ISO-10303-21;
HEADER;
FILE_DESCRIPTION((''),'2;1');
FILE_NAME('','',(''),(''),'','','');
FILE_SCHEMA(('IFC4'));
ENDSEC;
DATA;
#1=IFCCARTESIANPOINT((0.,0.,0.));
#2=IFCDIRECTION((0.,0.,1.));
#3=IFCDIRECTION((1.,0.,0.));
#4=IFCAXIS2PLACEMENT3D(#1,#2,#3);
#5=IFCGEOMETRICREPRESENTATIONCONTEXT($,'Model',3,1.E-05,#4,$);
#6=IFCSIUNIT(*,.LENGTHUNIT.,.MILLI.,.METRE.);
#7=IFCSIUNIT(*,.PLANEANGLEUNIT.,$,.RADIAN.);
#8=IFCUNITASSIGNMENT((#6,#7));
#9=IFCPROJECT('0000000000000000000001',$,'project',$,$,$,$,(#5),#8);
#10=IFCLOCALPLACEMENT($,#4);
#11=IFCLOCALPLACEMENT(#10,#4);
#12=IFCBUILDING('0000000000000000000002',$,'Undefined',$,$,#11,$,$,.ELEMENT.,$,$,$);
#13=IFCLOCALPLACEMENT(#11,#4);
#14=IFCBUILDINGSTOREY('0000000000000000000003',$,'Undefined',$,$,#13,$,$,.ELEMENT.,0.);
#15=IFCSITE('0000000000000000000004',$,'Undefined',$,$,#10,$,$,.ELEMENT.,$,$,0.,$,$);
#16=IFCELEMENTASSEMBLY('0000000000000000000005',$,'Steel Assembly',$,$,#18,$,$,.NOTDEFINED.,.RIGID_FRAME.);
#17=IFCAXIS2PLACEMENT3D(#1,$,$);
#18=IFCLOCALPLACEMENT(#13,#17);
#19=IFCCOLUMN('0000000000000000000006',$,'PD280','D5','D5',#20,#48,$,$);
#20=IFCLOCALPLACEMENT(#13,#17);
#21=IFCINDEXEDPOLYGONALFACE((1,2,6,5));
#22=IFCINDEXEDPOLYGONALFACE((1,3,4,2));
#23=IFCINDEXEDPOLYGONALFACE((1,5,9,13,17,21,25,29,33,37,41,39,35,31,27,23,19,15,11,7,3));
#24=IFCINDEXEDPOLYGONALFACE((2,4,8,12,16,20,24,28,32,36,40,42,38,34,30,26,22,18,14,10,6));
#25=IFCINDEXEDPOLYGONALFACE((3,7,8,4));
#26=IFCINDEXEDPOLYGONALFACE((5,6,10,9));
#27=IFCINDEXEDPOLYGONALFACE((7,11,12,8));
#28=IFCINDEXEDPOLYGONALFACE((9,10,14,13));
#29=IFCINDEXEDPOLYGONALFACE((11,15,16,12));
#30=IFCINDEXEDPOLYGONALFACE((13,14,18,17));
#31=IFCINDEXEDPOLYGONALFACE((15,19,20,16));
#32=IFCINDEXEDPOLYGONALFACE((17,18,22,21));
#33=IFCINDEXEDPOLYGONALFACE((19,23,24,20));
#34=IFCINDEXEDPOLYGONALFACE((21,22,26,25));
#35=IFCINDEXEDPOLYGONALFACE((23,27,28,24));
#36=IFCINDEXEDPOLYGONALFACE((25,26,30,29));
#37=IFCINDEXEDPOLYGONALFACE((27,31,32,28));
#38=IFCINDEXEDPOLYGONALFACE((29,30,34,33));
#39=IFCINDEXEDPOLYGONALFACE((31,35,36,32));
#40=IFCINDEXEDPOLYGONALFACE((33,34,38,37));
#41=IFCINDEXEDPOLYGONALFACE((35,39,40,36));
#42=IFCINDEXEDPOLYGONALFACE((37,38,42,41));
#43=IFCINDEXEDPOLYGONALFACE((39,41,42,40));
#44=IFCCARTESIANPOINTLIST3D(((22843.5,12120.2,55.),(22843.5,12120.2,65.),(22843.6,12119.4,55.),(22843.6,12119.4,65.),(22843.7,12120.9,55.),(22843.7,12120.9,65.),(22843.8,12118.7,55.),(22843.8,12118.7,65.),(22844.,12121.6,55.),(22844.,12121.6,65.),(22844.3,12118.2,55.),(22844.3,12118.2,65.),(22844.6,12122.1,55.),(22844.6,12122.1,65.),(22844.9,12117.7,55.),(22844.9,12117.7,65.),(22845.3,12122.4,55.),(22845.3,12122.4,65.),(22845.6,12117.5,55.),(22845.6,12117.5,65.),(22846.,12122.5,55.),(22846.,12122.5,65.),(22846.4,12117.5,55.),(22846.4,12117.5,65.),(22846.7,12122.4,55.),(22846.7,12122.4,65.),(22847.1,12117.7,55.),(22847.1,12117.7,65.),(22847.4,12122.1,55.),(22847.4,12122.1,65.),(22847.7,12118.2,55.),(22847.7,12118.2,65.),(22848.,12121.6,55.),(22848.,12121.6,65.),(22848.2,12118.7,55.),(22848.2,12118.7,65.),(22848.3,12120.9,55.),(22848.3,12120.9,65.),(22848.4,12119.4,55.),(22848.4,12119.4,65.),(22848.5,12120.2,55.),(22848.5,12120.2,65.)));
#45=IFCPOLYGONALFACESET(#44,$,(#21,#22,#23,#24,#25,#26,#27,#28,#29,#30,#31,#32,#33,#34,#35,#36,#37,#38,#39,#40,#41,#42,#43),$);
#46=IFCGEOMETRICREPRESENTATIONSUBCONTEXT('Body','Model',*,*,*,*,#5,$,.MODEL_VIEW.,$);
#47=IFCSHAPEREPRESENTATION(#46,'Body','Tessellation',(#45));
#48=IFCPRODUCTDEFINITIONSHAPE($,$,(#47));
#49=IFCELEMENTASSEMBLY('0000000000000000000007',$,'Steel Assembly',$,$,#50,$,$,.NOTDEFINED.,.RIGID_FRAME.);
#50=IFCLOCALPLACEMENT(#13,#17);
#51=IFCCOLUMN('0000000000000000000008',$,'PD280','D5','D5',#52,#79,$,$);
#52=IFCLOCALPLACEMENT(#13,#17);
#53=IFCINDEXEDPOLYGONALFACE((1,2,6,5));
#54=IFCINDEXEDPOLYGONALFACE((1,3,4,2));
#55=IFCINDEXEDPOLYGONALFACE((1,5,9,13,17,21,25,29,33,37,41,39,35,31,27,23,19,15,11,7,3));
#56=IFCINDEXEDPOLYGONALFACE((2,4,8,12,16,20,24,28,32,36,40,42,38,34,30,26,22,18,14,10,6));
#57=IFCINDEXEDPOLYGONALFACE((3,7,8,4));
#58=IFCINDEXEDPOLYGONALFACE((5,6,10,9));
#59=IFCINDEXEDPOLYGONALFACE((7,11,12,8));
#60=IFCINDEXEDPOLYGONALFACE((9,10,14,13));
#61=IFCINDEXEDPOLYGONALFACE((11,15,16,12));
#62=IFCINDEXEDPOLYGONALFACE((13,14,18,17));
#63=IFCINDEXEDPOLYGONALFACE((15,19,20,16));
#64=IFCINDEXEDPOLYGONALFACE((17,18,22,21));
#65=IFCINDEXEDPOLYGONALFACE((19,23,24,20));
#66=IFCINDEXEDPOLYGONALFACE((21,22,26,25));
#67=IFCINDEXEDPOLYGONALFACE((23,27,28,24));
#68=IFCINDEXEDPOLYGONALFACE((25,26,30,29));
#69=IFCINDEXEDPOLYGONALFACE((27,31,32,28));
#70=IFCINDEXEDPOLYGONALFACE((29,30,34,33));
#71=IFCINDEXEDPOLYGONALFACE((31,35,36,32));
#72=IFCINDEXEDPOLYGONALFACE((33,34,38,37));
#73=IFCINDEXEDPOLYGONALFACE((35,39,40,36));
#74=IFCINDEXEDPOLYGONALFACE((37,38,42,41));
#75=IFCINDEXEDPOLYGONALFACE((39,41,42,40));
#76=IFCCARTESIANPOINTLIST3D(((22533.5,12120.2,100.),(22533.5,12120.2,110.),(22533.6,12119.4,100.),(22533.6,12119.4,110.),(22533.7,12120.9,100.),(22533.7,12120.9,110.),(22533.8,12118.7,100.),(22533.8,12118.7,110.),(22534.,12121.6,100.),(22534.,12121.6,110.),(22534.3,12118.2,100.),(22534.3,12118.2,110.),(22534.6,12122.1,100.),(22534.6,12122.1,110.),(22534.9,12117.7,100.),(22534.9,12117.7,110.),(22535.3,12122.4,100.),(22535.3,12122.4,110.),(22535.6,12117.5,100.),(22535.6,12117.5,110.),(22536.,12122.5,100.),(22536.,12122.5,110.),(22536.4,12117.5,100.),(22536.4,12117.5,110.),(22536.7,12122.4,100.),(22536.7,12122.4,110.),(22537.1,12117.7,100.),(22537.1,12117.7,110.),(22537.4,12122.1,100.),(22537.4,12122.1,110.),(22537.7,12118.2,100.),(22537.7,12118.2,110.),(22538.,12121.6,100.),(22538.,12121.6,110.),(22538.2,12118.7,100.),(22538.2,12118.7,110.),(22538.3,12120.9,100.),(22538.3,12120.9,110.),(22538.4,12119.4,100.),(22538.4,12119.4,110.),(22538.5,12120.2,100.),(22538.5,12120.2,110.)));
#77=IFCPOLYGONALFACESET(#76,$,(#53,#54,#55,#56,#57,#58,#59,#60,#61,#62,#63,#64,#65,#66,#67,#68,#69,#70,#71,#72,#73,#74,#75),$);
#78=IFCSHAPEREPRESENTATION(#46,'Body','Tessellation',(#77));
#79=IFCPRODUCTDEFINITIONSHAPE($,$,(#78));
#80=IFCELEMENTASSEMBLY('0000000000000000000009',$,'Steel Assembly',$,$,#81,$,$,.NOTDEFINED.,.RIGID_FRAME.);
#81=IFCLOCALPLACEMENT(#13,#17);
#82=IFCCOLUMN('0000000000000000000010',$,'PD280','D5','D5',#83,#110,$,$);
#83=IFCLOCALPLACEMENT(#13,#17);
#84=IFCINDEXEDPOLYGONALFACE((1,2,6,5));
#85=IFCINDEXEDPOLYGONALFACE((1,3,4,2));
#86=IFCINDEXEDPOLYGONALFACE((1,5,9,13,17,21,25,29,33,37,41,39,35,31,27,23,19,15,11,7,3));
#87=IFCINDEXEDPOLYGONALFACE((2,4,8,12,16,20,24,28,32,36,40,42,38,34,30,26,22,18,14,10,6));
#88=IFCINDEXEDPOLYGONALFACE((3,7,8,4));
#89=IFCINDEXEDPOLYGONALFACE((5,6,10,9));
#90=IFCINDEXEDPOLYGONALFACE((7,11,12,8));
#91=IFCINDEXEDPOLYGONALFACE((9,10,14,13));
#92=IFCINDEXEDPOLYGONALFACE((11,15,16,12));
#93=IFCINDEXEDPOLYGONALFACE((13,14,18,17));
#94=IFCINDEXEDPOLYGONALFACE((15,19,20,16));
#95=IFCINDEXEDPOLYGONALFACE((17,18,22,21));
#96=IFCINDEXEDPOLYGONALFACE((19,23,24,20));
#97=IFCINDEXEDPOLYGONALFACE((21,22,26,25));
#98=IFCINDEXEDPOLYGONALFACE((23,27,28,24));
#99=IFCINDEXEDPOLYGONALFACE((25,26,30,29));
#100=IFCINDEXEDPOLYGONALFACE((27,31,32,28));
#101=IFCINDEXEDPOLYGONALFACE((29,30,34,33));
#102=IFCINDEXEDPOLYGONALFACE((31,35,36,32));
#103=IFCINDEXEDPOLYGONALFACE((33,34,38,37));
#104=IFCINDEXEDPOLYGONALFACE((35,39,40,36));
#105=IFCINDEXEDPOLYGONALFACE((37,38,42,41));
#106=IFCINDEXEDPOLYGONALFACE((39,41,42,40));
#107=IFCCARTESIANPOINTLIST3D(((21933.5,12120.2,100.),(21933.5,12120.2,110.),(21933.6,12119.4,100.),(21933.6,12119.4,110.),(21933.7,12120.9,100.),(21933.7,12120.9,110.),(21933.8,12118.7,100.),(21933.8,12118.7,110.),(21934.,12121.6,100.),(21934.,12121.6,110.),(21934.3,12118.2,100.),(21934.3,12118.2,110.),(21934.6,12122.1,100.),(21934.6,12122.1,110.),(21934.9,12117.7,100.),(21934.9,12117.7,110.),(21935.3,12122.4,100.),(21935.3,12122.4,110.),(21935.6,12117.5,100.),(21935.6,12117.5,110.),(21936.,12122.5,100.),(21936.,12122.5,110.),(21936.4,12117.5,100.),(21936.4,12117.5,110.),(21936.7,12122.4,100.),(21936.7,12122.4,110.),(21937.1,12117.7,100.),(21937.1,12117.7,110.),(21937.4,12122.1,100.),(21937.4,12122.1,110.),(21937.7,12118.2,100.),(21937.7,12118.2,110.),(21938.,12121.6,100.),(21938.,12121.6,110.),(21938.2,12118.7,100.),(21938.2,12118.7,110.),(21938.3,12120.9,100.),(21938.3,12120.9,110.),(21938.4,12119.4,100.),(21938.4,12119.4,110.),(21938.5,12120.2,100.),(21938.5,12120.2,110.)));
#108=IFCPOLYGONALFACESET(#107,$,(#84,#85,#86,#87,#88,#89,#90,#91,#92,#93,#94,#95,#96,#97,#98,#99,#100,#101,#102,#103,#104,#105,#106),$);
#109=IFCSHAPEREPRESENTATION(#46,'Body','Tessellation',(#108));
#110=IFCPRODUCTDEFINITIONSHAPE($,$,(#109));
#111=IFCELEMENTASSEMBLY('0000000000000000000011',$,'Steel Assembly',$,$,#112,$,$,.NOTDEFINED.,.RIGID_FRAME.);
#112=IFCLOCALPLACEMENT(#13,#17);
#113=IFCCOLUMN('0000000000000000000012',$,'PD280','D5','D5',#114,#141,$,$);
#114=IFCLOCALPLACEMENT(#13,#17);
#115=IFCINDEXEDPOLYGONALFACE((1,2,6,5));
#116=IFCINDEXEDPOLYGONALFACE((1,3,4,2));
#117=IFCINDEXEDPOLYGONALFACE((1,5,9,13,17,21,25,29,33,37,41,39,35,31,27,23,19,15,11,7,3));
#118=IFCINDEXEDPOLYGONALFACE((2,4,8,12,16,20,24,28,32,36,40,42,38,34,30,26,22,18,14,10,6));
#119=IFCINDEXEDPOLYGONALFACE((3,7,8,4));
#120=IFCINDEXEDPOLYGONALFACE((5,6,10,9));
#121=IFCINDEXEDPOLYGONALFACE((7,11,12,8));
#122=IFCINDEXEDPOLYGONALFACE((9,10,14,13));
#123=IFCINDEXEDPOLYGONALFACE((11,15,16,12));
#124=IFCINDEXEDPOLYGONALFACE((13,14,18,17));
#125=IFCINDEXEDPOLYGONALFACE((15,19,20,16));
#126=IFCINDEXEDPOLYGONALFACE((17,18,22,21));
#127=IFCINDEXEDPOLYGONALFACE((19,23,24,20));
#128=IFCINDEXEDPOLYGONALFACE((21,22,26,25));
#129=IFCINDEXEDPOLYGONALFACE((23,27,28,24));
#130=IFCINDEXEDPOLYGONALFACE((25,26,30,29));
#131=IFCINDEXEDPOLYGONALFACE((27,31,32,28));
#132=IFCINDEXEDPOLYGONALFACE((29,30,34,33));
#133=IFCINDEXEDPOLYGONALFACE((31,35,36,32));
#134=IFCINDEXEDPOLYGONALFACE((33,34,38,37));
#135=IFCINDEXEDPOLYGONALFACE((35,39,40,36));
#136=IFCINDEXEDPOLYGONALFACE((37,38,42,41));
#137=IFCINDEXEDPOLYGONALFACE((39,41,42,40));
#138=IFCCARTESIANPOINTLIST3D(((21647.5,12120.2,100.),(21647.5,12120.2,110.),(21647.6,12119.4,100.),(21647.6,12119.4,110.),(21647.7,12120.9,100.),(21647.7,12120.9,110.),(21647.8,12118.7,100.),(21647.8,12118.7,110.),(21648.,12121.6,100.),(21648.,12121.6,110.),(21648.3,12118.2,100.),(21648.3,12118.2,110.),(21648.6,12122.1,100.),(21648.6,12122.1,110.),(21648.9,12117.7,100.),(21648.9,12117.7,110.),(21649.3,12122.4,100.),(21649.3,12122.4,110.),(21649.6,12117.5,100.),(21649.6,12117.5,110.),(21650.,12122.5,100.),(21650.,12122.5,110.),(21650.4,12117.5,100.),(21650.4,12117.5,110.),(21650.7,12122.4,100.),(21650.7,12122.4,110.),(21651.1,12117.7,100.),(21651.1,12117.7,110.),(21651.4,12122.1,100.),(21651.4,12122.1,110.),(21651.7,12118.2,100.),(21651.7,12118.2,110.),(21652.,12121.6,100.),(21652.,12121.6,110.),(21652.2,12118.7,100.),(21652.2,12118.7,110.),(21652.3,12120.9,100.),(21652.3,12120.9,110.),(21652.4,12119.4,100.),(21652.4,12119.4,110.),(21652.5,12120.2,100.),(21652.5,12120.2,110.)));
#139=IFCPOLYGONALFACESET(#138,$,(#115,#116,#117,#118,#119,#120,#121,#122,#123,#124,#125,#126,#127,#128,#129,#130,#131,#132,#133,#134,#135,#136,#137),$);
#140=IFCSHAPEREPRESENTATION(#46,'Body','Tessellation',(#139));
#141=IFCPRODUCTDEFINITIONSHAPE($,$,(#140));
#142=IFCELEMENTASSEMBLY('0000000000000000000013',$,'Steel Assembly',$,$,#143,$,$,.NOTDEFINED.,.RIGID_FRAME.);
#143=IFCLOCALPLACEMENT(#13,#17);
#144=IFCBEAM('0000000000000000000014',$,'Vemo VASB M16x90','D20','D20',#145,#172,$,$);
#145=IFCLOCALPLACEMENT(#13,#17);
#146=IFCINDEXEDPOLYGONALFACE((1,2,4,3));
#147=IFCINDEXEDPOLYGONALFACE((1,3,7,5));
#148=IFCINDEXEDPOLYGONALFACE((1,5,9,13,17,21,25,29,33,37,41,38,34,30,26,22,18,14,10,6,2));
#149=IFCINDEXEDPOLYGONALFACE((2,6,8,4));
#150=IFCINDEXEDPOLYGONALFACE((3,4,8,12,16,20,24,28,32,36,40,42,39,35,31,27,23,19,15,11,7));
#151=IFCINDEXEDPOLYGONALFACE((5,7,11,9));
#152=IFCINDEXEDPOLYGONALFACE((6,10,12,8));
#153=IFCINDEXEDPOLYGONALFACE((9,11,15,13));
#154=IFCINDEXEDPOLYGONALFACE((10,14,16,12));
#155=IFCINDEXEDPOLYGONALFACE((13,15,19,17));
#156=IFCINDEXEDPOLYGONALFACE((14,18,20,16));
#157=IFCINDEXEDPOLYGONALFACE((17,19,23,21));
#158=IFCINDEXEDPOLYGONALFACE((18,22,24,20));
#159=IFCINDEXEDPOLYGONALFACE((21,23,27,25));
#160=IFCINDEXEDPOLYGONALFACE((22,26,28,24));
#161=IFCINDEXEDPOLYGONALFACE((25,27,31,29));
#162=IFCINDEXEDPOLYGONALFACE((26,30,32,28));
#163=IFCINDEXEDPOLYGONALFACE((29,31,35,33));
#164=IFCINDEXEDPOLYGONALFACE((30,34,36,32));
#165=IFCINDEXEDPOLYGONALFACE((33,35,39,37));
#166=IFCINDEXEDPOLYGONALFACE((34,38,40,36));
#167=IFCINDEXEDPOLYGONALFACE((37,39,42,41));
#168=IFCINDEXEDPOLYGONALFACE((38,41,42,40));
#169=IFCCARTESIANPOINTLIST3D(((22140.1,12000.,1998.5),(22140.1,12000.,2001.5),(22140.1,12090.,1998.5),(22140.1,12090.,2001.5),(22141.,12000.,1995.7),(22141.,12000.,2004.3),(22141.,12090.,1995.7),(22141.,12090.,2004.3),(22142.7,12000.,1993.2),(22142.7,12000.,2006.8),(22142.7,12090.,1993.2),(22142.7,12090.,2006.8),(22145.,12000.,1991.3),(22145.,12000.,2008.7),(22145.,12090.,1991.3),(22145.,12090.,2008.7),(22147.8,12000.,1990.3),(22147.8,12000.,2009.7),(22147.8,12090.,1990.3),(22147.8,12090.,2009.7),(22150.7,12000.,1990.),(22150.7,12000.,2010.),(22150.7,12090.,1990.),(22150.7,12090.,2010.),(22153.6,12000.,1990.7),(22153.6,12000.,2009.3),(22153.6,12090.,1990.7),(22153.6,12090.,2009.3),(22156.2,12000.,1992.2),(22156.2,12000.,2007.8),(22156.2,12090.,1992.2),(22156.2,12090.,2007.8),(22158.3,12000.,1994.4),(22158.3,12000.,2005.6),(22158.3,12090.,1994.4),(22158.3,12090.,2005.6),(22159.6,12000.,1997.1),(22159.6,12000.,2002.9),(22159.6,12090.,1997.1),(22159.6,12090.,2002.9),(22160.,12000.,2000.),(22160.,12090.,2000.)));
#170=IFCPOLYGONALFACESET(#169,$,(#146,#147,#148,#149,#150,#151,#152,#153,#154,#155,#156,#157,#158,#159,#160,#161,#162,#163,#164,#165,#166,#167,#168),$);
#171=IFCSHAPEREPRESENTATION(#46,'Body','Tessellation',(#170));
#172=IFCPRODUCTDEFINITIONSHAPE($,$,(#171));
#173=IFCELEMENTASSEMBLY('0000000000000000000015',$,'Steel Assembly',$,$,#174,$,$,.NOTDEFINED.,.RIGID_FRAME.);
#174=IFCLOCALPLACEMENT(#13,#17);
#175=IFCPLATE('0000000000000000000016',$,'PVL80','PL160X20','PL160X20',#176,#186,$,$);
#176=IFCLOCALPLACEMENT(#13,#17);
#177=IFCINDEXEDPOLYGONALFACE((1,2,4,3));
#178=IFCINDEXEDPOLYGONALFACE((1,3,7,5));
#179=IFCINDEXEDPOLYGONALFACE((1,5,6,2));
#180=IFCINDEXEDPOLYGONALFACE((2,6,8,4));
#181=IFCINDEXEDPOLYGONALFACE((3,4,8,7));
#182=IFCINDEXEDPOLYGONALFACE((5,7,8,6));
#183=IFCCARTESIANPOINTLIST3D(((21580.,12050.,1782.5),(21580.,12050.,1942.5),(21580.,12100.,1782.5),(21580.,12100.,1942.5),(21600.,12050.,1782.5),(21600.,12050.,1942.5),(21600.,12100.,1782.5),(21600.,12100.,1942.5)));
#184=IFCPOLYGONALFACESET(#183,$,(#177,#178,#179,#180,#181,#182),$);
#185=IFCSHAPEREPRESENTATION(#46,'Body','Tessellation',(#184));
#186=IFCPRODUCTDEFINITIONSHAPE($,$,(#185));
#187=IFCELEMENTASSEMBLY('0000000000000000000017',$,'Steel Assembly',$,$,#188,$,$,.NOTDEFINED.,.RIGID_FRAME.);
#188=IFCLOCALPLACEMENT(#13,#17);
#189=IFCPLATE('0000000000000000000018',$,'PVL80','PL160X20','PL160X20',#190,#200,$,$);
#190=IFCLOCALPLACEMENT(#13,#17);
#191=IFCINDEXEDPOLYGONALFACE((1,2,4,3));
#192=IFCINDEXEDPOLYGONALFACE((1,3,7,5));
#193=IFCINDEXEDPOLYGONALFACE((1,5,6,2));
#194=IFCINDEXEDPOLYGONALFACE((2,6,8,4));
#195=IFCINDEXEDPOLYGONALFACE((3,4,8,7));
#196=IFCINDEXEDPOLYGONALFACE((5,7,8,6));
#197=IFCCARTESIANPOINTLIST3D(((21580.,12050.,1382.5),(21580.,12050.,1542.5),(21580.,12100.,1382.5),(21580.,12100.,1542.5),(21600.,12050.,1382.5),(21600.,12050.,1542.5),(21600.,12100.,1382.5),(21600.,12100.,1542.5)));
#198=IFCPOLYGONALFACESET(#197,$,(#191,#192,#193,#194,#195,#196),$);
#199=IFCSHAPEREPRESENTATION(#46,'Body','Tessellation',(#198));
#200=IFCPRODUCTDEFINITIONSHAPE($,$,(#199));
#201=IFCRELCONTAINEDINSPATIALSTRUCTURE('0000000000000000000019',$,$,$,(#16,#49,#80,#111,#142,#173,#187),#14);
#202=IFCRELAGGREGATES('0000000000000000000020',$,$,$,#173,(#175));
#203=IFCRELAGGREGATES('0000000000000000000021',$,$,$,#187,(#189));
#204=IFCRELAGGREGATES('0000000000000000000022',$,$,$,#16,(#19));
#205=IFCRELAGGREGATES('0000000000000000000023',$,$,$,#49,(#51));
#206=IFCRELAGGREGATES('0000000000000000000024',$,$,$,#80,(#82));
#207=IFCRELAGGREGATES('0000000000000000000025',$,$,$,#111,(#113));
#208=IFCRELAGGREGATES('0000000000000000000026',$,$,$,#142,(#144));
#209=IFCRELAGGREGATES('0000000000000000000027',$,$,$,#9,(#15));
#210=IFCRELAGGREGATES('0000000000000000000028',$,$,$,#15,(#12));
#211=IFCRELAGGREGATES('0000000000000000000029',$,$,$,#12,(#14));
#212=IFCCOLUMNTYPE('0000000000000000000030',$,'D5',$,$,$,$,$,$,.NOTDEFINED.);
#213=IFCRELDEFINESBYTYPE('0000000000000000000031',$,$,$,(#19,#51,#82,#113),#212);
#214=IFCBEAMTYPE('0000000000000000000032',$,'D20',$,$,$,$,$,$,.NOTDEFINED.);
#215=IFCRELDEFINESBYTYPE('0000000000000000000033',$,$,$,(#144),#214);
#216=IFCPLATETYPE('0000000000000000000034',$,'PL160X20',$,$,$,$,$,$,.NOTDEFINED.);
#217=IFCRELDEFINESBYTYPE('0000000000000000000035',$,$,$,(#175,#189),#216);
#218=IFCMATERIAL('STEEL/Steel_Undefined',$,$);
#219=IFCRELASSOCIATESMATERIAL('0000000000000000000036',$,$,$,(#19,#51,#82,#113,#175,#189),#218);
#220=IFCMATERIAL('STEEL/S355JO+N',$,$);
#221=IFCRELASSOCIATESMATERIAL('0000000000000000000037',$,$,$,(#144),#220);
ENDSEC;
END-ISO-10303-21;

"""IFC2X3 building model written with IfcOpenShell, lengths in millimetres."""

from ifc_helpers import new_model, si_unit, frame, origin_with_axes, origin_2d_with_axis, place, context, subcontext, project, spatial, polyline, circle, outline, extrude, material, type_object, element, aggregate, save


model = new_model("IFC2X3")

# Units and contexts
model_context = context("Model", 3, precision=1e-05, world=origin_with_axes())
body_context = subcontext(model_context, "Body", "Model", "MODEL_VIEW")
ifc_project = project(units=[si_unit("LENGTHUNIT", "METRE", prefix="MILLI"), si_unit("PLANEANGLEUNIT", "RADIAN")], contexts=[model_context])

# Site, building, storey
site_placement = place(None, origin_with_axes())
site = spatial("IfcSite", under=ifc_project, at=site_placement, Name="Undefined", CompositionType="ELEMENT", RefElevation=0.0)
building_placement = place(site_placement, origin_with_axes())
building = spatial("IfcBuilding", under=site, at=building_placement, Name="Undefined", CompositionType="ELEMENT")
storey_placement = place(building_placement, origin_with_axes())
storey = spatial("IfcBuildingStorey", under=building, at=storey_placement, Name="Undefined", CompositionType="ELEMENT", Elevation=0.0)

# Element assemblies, columns
assembly_1_placement = place(storey_placement, origin_with_axes())
assembly_1 = element("IfcElementAssembly", 1, at=assembly_1_placement, inside=storey, Name="Steel Assembly", AssemblyPlace="NOTDEFINED", PredefinedType="RIGID_FRAME")
ifc_material_1 = material(Name="STEEL/Steel_Undefined")
column_type = type_object("IfcColumnType", Name="D5", PredefinedType="NOTDEFINED")
column_1_placement = place(assembly_1_placement, frame((22846.0, 12120.0, 55.0), z_axis=(0.0, 0.0, 1.0), x_axis=(1.0, 0.0, 0.0)))
column_1 = element("IfcColumn", 2, at=column_1_placement, type_object=column_type, material=ifc_material_1, Name="PD280", Description="D5", ObjectType="D5", context=body_context, shape_type="SweptSolid", body=[
    extrude(circle(Radius=2.5, at=origin_2d_with_axis()), frame((0.0, 0.0, 10.0), z_axis=(0.0, 0.0, -1.0), x_axis=(0.0, 1.0, 0.0)), (0.0, 0.0, 1.0), 10.0),
])
assembly_2_placement = place(storey_placement, origin_with_axes())
assembly_2 = element("IfcElementAssembly", 3, at=assembly_2_placement, inside=storey, Name="Steel Assembly", AssemblyPlace="NOTDEFINED", PredefinedType="RIGID_FRAME")
column_2_placement = place(assembly_2_placement, frame((22536.0, 12120.0, 100.0), z_axis=(0.0, 0.0, 1.0), x_axis=(1.0, 0.0, 0.0)))
column_2 = element("IfcColumn", 4, at=column_2_placement, type_object=column_type, material=ifc_material_1, Name="PD280", Description="D5", ObjectType="D5", context=body_context, shape_type="SweptSolid", body=[
    extrude(circle(Radius=2.5, at=origin_2d_with_axis()), frame((0.0, 0.0, 10.0), z_axis=(0.0, 0.0, -1.0), x_axis=(0.0, 1.0, 0.0)), (0.0, 0.0, 1.0), 10.0),
])
assembly_3_placement = place(storey_placement, origin_with_axes())
assembly_3 = element("IfcElementAssembly", 5, at=assembly_3_placement, inside=storey, Name="Steel Assembly", AssemblyPlace="NOTDEFINED", PredefinedType="RIGID_FRAME")
column_3_placement = place(assembly_3_placement, frame((21936.0, 12120.0, 100.0), z_axis=(0.0, 0.0, 1.0), x_axis=(1.0, 0.0, 0.0)))
column_3 = element("IfcColumn", 6, at=column_3_placement, type_object=column_type, material=ifc_material_1, Name="PD280", Description="D5", ObjectType="D5", context=body_context, shape_type="SweptSolid", body=[
    extrude(circle(Radius=2.5, at=origin_2d_with_axis()), frame((0.0, 0.0, 10.0), z_axis=(0.0, 0.0, -1.0), x_axis=(0.0, 1.0, 0.0)), (0.0, 0.0, 1.0), 10.0),
])
assembly_4_placement = place(storey_placement, origin_with_axes())
assembly_4 = element("IfcElementAssembly", 7, at=assembly_4_placement, inside=storey, Name="Steel Assembly", AssemblyPlace="NOTDEFINED", PredefinedType="RIGID_FRAME")
column_4_placement = place(assembly_4_placement, frame((21650.0, 12120.0, 100.0), z_axis=(0.0, 0.0, 1.0), x_axis=(1.0, 0.0, 0.0)))
column_4 = element("IfcColumn", 8, at=column_4_placement, type_object=column_type, material=ifc_material_1, Name="PD280", Description="D5", ObjectType="D5", context=body_context, shape_type="SweptSolid", body=[
    extrude(circle(Radius=2.5, at=origin_2d_with_axis()), frame((0.0, 0.0, 10.0), z_axis=(0.0, 0.0, -1.0), x_axis=(0.0, 1.0, 0.0)), (0.0, 0.0, 1.0), 10.0),
])

# Element assembly, beam
assembly_5_placement = place(storey_placement, origin_with_axes())
assembly_5 = element("IfcElementAssembly", 9, at=assembly_5_placement, inside=storey, Name="Steel Assembly", AssemblyPlace="NOTDEFINED", PredefinedType="RIGID_FRAME")
ifc_material_2 = material(Name="STEEL/S355JO+N")
beam_type = type_object("IfcBeamType", Name="D20", PredefinedType="NOTDEFINED")
beam_placement = place(assembly_5_placement, frame((22150.0, 12000.0, 2000.0), z_axis=(0.0, 0.0, 1.0), x_axis=(0.0, 1.0, 0.0)))
beam = element("IfcBeam", 10, at=beam_placement, type_object=beam_type, material=ifc_material_2, Name="Vemo VASB M16x90", Description="D20", ObjectType="D20", context=body_context, shape_type="SweptSolid", body=[
    extrude(circle(Radius=10.0, at=origin_2d_with_axis()), frame((90.0, 0.0, 0.0), z_axis=(-1.0, 0.0, 0.0), x_axis=(0.0, -1.0, 0.0)), (0.0, 0.0, 1.0), 90.0),
])

# Element assemblies, plates
assembly_6_placement = place(storey_placement, origin_with_axes())
assembly_6 = element("IfcElementAssembly", 11, at=assembly_6_placement, inside=storey, Name="Steel Assembly", AssemblyPlace="NOTDEFINED", PredefinedType="RIGID_FRAME")
plate_type = type_object("IfcPlateType", Name="PL160X20", PredefinedType="NOTDEFINED")
plate_1_placement = place(assembly_6_placement, frame((21580.0, 12050.0, 1862.5), z_axis=(0.0, 0.0, -1.0), x_axis=(0.0, 1.0, 0.0)))
plate_1 = element("IfcPlate", 12, at=plate_1_placement, type_object=plate_type, material=ifc_material_1, Name="PVL80", Description="PL160X20", ObjectType="PL160X20", context=body_context, shape_type="SweptSolid", body=[
    extrude(outline(polyline([(0.0, 0.0), (50.0, 0.0), (50.0, 20.0), (0.0, 20.0), (0.0, 0.0)])), frame((0.0, 0.0, -80.0), z_axis=(0.0, 0.0, 1.0), x_axis=(1.0, 0.0, 0.0)), (0.0, 0.0, 1.0), 160.0),
])
assembly_7_placement = place(storey_placement, origin_with_axes())
assembly_7 = element("IfcElementAssembly", 13, at=assembly_7_placement, inside=storey, Name="Steel Assembly", AssemblyPlace="NOTDEFINED", PredefinedType="RIGID_FRAME")
plate_2_placement = place(assembly_7_placement, frame((21580.0, 12050.0, 1462.5), z_axis=(0.0, 0.0, -1.0), x_axis=(0.0, 1.0, 0.0)))
plate_2 = element("IfcPlate", 14, at=plate_2_placement, type_object=plate_type, material=ifc_material_1, Name="PVL80", Description="PL160X20", ObjectType="PL160X20", context=body_context, shape_type="SweptSolid", body=[
    extrude(outline(polyline([(0.0, 0.0), (50.0, 0.0), (50.0, 20.0), (0.0, 20.0), (0.0, 0.0)])), frame((0.0, 0.0, -80.0), z_axis=(0.0, 0.0, 1.0), x_axis=(1.0, 0.0, 0.0)), (0.0, 0.0, 1.0), 160.0),
])

aggregate(assembly_6, [plate_1])
aggregate(assembly_7, [plate_2])

aggregate(assembly_1, [column_1])
aggregate(assembly_2, [column_2])
aggregate(assembly_3, [column_3])
aggregate(assembly_4, [column_4])

aggregate(assembly_5, [beam])

save(model, "model.ifc")
